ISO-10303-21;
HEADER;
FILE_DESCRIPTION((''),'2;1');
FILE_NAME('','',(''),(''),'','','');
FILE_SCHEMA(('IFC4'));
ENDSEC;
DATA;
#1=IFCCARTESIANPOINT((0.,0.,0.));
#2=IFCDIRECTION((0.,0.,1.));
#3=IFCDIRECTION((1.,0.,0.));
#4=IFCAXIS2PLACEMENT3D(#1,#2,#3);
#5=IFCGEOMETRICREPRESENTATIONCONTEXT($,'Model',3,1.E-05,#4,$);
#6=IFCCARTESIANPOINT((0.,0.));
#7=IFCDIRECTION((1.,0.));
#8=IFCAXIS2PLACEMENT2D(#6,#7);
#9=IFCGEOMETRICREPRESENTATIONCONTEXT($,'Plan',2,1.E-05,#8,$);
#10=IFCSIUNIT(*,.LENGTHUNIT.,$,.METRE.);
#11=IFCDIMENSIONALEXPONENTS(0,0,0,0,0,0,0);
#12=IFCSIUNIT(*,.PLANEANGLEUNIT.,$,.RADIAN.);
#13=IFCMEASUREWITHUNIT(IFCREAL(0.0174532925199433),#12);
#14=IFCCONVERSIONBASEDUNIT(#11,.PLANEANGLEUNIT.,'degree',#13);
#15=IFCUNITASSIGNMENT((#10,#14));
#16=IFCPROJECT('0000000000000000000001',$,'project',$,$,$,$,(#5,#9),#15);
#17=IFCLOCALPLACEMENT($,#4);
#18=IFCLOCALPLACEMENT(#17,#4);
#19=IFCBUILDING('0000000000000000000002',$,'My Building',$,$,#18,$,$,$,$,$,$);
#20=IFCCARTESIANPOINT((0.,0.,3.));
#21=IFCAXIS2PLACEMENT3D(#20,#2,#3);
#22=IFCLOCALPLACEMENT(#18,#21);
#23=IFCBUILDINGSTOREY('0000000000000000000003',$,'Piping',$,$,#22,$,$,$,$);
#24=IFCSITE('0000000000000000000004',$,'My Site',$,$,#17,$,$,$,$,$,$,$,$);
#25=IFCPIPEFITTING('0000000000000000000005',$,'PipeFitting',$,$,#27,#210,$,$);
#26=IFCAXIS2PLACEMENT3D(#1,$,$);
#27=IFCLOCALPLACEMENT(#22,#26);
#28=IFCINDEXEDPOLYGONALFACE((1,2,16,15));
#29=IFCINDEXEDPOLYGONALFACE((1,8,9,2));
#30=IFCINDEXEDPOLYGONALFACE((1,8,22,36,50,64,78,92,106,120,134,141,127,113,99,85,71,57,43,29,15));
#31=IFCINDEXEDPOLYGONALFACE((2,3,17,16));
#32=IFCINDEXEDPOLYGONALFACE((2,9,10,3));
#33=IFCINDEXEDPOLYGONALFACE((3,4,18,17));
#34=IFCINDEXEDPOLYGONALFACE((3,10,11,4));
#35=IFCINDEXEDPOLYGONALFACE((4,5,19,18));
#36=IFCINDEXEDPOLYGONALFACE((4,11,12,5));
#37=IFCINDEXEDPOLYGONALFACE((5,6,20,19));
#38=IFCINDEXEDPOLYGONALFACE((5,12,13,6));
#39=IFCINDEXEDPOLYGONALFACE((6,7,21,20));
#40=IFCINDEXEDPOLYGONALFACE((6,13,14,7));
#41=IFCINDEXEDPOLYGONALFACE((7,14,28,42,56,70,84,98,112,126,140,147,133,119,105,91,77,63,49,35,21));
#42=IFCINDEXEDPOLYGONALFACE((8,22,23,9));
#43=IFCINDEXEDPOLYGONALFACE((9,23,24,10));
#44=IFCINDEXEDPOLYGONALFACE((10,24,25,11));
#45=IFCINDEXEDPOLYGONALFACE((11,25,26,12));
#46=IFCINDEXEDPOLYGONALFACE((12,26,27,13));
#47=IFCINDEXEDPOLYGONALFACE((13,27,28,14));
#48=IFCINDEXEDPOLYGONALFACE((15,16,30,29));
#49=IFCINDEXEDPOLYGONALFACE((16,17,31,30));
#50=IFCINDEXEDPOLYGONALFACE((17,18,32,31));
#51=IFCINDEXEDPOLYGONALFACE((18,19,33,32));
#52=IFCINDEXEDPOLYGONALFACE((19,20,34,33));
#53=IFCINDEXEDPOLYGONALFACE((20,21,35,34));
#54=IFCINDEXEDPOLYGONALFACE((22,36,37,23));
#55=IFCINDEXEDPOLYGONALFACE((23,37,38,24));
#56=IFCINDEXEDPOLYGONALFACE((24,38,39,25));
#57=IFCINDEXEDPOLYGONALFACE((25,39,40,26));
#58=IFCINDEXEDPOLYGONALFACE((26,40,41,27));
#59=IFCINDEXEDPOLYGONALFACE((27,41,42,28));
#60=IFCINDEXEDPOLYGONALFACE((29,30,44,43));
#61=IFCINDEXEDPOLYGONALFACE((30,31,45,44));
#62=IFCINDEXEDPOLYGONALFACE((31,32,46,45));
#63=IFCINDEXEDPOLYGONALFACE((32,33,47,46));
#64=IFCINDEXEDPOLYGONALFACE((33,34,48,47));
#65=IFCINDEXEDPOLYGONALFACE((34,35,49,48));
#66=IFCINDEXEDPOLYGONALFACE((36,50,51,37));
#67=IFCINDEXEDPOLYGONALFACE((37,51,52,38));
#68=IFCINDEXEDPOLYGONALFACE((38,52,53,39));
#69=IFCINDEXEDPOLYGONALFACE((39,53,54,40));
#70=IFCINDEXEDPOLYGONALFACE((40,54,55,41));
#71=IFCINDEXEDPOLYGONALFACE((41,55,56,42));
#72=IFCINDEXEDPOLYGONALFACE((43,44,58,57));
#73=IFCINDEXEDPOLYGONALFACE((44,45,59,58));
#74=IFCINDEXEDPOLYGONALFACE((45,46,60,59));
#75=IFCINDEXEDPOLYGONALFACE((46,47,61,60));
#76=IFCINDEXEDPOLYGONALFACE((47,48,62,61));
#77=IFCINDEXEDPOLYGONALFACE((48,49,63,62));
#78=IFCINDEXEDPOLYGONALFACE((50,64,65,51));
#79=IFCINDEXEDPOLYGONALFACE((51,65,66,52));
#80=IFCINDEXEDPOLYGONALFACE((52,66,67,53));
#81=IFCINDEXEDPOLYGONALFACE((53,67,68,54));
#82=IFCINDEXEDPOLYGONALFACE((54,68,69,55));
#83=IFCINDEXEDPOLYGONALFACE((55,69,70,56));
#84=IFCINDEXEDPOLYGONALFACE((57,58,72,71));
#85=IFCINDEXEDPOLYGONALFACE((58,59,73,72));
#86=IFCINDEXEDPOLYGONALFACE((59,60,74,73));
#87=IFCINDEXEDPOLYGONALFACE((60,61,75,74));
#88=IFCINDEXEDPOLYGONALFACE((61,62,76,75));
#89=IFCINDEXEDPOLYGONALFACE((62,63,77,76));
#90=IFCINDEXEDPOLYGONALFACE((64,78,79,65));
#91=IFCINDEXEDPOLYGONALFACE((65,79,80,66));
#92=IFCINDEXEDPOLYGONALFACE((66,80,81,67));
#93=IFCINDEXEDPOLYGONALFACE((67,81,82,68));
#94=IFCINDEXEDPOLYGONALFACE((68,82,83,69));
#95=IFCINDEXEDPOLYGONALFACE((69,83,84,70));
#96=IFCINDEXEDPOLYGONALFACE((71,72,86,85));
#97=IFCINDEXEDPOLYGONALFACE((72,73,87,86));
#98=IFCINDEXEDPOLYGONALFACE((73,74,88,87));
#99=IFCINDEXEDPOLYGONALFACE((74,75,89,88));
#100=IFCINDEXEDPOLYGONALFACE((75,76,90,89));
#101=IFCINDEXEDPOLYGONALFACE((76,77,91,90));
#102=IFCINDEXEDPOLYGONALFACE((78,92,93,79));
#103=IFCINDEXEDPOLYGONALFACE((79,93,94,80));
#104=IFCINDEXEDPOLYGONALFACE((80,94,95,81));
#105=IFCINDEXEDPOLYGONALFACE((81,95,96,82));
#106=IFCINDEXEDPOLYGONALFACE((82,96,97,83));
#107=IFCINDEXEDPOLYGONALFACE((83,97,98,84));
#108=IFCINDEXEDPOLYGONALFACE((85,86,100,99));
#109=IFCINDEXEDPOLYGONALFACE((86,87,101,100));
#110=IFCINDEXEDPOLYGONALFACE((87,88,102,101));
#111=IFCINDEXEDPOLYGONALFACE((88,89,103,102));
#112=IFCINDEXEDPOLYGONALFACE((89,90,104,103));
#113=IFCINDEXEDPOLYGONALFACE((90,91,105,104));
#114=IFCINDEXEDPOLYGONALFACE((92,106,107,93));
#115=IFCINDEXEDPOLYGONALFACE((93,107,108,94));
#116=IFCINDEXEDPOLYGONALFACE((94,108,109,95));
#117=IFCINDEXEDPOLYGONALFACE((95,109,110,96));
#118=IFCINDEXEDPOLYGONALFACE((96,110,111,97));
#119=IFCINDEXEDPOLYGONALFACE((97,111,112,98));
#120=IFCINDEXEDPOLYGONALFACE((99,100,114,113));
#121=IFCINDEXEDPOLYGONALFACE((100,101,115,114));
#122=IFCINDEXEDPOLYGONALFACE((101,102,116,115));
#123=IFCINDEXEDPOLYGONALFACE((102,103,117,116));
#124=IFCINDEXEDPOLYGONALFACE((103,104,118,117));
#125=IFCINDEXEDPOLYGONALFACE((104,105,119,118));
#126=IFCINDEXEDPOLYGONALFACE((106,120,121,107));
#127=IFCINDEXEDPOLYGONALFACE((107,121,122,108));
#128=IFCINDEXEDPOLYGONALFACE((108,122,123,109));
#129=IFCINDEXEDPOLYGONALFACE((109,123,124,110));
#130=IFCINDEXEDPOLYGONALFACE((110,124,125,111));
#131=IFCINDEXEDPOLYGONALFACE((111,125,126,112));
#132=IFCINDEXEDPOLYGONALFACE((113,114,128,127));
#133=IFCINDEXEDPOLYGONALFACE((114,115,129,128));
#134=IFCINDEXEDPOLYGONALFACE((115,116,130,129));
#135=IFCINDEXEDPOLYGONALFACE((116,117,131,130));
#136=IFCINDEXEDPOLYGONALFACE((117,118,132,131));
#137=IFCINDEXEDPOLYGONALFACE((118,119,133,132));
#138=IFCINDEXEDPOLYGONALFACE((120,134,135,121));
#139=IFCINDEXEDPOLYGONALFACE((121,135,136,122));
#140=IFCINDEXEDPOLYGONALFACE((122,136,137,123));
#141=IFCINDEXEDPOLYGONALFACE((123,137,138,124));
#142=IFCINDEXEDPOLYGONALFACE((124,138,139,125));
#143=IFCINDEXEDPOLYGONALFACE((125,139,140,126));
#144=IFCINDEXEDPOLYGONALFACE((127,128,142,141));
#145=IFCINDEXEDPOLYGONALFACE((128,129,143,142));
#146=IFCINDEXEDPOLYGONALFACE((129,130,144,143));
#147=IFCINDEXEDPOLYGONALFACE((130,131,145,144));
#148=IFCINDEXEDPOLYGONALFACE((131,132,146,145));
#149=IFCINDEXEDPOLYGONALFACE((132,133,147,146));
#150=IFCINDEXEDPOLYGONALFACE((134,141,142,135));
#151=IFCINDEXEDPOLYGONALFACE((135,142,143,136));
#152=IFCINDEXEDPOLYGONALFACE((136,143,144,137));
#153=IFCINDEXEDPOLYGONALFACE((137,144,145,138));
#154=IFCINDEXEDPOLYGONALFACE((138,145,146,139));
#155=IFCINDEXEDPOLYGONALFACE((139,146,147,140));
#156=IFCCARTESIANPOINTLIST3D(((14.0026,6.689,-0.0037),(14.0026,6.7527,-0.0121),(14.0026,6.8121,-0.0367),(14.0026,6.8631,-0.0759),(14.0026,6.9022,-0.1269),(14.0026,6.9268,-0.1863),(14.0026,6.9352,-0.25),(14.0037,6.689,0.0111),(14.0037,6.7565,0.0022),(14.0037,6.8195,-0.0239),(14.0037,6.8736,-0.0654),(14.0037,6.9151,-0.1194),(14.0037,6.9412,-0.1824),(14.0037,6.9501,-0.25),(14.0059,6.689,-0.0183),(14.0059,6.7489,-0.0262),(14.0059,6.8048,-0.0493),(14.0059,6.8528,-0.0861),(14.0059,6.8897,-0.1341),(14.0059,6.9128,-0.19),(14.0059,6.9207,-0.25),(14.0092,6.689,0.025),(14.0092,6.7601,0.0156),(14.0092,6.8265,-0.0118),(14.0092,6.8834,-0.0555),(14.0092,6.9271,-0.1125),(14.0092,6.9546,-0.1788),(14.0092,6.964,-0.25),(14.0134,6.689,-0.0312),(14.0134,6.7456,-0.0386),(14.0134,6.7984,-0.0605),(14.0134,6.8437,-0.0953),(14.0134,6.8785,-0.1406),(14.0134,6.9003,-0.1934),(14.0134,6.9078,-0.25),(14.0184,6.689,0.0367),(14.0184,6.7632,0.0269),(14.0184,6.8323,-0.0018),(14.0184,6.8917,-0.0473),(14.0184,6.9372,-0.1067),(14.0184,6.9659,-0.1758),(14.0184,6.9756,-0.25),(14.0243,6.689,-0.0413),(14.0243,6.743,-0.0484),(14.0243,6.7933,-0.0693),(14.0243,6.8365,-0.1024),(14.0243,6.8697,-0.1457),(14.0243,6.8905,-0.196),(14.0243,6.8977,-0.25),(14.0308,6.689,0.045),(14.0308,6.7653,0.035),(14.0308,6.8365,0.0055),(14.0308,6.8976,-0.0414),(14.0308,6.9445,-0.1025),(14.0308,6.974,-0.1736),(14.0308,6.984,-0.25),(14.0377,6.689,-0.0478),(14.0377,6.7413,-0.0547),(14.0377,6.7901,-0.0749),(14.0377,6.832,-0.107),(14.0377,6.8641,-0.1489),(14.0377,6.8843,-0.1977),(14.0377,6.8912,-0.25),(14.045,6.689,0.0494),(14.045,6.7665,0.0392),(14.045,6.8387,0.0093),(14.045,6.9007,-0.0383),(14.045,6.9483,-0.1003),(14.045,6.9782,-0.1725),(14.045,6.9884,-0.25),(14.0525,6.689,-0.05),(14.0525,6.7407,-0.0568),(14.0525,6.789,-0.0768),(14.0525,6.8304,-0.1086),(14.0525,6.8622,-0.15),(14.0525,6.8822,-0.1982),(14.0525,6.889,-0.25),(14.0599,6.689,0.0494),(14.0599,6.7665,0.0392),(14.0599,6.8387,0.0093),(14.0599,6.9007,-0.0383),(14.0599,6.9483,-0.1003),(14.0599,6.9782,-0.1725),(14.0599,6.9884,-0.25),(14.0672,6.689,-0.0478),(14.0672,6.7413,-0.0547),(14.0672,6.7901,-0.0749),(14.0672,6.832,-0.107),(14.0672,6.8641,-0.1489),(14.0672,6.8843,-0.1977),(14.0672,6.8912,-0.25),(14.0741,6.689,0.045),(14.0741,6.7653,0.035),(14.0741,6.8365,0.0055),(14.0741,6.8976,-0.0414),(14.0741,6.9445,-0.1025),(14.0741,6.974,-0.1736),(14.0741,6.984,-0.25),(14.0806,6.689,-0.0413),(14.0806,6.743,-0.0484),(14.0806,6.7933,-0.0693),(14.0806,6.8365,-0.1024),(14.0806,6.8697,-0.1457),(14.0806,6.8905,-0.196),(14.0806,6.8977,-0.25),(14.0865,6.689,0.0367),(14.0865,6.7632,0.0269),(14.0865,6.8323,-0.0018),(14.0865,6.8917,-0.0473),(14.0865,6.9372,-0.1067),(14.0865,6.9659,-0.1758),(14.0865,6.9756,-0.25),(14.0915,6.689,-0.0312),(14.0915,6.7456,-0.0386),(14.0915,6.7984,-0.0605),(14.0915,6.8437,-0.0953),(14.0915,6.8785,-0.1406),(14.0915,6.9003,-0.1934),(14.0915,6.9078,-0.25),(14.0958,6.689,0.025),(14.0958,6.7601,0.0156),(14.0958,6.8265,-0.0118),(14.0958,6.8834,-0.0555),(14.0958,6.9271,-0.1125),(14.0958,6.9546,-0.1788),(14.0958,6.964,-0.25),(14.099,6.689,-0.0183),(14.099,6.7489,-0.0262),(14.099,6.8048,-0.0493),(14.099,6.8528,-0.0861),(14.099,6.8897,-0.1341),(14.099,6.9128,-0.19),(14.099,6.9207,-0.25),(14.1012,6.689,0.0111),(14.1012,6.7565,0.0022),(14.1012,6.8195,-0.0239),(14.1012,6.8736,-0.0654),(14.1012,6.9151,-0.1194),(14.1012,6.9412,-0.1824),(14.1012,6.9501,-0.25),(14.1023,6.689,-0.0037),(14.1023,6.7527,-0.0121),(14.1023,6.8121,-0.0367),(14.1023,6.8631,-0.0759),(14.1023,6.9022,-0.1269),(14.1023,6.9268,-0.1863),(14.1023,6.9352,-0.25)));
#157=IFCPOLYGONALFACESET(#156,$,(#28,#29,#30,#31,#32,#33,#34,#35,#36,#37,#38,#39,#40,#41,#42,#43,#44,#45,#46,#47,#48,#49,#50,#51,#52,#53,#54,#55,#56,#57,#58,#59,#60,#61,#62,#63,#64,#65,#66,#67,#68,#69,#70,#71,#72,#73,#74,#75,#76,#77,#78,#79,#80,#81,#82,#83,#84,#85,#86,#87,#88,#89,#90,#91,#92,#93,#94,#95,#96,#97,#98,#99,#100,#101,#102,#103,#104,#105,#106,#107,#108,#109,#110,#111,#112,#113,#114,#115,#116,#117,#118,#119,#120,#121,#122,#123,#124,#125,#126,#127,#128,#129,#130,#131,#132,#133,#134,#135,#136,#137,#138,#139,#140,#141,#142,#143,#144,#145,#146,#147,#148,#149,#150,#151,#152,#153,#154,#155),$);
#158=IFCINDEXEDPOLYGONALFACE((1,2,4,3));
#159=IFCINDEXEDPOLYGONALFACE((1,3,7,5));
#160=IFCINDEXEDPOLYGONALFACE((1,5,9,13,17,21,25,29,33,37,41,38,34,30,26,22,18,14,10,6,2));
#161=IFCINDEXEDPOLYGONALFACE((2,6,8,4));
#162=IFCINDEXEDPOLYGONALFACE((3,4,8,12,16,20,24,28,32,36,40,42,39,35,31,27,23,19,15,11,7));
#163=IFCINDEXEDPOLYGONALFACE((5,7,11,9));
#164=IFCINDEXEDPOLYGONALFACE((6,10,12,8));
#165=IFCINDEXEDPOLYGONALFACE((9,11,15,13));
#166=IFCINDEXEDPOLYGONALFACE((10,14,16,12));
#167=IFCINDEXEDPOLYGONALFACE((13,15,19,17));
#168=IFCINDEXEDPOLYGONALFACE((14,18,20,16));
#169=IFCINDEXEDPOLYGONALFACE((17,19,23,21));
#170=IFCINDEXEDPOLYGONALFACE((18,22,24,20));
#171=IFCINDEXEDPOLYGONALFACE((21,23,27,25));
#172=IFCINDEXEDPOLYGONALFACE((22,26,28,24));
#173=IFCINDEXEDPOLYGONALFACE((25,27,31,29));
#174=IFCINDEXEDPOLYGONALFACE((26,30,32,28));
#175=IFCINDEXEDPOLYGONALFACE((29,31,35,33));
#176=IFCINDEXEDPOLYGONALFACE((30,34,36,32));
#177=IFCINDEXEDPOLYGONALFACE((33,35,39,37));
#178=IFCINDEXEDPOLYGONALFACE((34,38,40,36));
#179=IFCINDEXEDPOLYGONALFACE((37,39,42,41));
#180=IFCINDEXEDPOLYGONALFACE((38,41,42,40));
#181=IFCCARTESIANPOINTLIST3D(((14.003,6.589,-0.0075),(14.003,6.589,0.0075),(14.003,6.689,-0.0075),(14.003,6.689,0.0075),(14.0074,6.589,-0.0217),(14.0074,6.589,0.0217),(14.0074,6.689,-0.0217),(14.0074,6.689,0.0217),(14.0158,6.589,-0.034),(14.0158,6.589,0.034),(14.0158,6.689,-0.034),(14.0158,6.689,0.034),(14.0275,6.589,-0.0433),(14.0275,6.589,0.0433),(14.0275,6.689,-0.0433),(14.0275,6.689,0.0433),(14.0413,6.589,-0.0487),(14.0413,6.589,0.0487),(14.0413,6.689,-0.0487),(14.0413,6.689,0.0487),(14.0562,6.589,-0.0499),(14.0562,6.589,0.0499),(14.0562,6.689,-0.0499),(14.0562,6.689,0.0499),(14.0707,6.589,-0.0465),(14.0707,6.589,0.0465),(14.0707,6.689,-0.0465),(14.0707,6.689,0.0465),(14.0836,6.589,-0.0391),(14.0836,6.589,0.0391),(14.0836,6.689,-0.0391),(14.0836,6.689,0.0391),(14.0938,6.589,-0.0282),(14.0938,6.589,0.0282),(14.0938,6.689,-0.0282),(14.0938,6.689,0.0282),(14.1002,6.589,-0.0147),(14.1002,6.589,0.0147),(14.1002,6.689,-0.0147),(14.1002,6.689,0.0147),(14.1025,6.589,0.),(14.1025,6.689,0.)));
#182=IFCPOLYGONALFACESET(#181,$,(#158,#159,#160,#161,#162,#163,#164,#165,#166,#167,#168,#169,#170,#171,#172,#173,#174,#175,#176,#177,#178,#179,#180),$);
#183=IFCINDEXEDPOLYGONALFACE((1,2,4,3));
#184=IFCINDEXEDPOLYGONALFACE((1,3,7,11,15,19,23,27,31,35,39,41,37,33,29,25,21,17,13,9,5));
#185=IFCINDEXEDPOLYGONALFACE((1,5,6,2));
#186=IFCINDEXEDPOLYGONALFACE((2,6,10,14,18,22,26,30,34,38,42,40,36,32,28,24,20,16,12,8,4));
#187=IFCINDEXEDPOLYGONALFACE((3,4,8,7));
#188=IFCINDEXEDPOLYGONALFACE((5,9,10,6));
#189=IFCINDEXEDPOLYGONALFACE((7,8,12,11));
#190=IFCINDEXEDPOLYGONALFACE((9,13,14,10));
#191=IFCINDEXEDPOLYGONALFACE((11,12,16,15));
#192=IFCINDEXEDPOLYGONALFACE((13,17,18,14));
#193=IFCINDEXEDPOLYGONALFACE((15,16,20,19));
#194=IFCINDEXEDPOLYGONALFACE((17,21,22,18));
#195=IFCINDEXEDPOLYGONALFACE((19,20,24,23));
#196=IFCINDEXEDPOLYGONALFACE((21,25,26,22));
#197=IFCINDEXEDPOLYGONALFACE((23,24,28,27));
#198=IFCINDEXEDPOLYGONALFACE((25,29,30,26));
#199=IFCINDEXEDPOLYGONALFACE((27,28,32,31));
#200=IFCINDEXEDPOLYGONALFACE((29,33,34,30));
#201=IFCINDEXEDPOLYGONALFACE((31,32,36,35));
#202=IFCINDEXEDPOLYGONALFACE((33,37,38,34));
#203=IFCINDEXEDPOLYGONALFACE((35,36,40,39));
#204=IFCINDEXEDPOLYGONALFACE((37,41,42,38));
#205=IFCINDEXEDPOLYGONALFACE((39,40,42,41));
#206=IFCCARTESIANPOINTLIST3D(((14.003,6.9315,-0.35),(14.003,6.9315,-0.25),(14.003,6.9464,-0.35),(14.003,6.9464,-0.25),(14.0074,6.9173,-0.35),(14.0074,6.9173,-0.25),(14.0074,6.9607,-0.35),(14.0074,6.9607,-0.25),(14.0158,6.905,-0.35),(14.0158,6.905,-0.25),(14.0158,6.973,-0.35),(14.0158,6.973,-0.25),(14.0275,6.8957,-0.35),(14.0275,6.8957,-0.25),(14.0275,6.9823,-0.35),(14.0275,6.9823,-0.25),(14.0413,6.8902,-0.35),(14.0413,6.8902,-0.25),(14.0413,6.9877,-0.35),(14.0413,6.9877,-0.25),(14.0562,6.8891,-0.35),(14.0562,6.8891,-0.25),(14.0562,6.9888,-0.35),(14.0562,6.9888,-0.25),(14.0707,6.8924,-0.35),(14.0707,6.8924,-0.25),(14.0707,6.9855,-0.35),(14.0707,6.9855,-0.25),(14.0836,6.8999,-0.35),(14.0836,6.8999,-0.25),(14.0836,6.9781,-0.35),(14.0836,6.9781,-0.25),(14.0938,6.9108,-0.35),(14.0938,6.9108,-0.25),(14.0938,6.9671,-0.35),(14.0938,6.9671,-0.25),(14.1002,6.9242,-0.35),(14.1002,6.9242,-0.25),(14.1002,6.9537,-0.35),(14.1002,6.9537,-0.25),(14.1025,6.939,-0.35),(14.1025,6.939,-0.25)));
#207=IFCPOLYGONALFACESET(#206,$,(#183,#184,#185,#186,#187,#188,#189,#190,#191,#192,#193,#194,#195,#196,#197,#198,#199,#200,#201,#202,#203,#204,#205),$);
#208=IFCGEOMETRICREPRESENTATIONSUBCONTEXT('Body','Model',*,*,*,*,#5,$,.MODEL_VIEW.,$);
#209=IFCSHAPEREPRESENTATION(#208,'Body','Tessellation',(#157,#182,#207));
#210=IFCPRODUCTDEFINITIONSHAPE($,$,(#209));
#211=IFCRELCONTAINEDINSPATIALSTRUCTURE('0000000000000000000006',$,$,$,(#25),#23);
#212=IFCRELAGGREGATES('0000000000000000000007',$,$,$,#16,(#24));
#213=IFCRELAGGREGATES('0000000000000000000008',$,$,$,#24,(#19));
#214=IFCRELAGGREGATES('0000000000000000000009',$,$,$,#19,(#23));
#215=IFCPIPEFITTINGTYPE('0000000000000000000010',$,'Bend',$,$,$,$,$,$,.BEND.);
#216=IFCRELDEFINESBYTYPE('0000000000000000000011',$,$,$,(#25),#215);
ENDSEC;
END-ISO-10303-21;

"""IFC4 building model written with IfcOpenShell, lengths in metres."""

from ifc_helpers import new_model, entity, si_unit, converted_unit, frame, origin_with_axes, origin_2d_with_axis, place, context, subcontext, project, spatial, circle, extrude, source, transform, mapped, type_object, type_shapes, element, save


model = new_model("IFC4")

# Units and contexts
model_context = context("Model", 3, precision=1e-05, world=origin_with_axes())
plan_context = context("Plan", 2, precision=1e-05, world=origin_2d_with_axis())
body_context = subcontext(model_context, "Body", "Model", "MODEL_VIEW")
ifc_project = project(units=[si_unit("LENGTHUNIT", "METRE"), converted_unit("PLANEANGLEUNIT", "degree", entity("IfcReal", 0.0174532925199433), si_unit("PLANEANGLEUNIT", "RADIAN"), dimensions=[0, 0, 0, 0, 0, 0, 0])], contexts=[model_context, plan_context])

# Site, building, storey
site_placement = place(None, origin_with_axes())
site = spatial("IfcSite", under=ifc_project, at=site_placement, Name="My Site")
building_placement = place(site_placement, origin_with_axes())
building = spatial("IfcBuilding", under=site, at=building_placement, Name="My Building")
storey_placement = place(building_placement, frame((0.0, 0.0, 3.0), z_axis=(0.0, 0.0, 1.0), x_axis=(1.0, 0.0, 0.0)))
storey = spatial("IfcBuildingStorey", under=building, at=storey_placement, Name="Piping")

# Pipe fitting
pipe_fitting_type_1 = type_object("IfcPipeFittingType", Name="Bend", PredefinedType="BEND")
shared_shape = source(origin_with_axes(), body_context, "Body", "SolidModel", [
    entity("IfcSweptDiskSolid", entity("IfcIndexedPolyCurve", entity("IfcCartesianPointList3D", [[0.0, 0.0, -0.1], [0.0, -0.0732, -0.2768], [0.0, -0.25, -0.35]]), [entity("IfcArcIndex", [1, 2, 3])]), 0.05),
    extrude(circle(Radius=0.05), origin_with_axes(), (0.0, 0.0, -1.0), 0.1),
    extrude(circle(Radius=0.05), frame((0.0, -0.25, -0.35), z_axis=(0.0, -1.0, 0.0), x_axis=(1.0, 0.0, 0.0)), (0.0, 0.0, 1.0), 0.1),
])
type_shapes(pipe_fitting_type_1, [shared_shape])
for number, where, z_axis, x_axis, name in (
    (1, (14.0525, 6.589, 0.0), (0.0, -1.0, 0.0), (1.0, 0.0, 0.0), "PipeFitting"),
):
    element("IfcPipeFitting", number, at=place(storey_placement, frame(where, z_axis=z_axis, x_axis=x_axis)), inside=storey, type_object=pipe_fitting_type_1, Name=name, context=body_context, shape_type="MappedRepresentation", body=[
        mapped(shared_shape, transform((0.0, 0.0, 0.0), x_axis=(1.0, 0.0, 0.0), y_axis=(0.0, 1.0, 0.0), z_axis=(0.0, 0.0, 1.0), scale=1.0)),
    ])

save(model, "model.ifc")
